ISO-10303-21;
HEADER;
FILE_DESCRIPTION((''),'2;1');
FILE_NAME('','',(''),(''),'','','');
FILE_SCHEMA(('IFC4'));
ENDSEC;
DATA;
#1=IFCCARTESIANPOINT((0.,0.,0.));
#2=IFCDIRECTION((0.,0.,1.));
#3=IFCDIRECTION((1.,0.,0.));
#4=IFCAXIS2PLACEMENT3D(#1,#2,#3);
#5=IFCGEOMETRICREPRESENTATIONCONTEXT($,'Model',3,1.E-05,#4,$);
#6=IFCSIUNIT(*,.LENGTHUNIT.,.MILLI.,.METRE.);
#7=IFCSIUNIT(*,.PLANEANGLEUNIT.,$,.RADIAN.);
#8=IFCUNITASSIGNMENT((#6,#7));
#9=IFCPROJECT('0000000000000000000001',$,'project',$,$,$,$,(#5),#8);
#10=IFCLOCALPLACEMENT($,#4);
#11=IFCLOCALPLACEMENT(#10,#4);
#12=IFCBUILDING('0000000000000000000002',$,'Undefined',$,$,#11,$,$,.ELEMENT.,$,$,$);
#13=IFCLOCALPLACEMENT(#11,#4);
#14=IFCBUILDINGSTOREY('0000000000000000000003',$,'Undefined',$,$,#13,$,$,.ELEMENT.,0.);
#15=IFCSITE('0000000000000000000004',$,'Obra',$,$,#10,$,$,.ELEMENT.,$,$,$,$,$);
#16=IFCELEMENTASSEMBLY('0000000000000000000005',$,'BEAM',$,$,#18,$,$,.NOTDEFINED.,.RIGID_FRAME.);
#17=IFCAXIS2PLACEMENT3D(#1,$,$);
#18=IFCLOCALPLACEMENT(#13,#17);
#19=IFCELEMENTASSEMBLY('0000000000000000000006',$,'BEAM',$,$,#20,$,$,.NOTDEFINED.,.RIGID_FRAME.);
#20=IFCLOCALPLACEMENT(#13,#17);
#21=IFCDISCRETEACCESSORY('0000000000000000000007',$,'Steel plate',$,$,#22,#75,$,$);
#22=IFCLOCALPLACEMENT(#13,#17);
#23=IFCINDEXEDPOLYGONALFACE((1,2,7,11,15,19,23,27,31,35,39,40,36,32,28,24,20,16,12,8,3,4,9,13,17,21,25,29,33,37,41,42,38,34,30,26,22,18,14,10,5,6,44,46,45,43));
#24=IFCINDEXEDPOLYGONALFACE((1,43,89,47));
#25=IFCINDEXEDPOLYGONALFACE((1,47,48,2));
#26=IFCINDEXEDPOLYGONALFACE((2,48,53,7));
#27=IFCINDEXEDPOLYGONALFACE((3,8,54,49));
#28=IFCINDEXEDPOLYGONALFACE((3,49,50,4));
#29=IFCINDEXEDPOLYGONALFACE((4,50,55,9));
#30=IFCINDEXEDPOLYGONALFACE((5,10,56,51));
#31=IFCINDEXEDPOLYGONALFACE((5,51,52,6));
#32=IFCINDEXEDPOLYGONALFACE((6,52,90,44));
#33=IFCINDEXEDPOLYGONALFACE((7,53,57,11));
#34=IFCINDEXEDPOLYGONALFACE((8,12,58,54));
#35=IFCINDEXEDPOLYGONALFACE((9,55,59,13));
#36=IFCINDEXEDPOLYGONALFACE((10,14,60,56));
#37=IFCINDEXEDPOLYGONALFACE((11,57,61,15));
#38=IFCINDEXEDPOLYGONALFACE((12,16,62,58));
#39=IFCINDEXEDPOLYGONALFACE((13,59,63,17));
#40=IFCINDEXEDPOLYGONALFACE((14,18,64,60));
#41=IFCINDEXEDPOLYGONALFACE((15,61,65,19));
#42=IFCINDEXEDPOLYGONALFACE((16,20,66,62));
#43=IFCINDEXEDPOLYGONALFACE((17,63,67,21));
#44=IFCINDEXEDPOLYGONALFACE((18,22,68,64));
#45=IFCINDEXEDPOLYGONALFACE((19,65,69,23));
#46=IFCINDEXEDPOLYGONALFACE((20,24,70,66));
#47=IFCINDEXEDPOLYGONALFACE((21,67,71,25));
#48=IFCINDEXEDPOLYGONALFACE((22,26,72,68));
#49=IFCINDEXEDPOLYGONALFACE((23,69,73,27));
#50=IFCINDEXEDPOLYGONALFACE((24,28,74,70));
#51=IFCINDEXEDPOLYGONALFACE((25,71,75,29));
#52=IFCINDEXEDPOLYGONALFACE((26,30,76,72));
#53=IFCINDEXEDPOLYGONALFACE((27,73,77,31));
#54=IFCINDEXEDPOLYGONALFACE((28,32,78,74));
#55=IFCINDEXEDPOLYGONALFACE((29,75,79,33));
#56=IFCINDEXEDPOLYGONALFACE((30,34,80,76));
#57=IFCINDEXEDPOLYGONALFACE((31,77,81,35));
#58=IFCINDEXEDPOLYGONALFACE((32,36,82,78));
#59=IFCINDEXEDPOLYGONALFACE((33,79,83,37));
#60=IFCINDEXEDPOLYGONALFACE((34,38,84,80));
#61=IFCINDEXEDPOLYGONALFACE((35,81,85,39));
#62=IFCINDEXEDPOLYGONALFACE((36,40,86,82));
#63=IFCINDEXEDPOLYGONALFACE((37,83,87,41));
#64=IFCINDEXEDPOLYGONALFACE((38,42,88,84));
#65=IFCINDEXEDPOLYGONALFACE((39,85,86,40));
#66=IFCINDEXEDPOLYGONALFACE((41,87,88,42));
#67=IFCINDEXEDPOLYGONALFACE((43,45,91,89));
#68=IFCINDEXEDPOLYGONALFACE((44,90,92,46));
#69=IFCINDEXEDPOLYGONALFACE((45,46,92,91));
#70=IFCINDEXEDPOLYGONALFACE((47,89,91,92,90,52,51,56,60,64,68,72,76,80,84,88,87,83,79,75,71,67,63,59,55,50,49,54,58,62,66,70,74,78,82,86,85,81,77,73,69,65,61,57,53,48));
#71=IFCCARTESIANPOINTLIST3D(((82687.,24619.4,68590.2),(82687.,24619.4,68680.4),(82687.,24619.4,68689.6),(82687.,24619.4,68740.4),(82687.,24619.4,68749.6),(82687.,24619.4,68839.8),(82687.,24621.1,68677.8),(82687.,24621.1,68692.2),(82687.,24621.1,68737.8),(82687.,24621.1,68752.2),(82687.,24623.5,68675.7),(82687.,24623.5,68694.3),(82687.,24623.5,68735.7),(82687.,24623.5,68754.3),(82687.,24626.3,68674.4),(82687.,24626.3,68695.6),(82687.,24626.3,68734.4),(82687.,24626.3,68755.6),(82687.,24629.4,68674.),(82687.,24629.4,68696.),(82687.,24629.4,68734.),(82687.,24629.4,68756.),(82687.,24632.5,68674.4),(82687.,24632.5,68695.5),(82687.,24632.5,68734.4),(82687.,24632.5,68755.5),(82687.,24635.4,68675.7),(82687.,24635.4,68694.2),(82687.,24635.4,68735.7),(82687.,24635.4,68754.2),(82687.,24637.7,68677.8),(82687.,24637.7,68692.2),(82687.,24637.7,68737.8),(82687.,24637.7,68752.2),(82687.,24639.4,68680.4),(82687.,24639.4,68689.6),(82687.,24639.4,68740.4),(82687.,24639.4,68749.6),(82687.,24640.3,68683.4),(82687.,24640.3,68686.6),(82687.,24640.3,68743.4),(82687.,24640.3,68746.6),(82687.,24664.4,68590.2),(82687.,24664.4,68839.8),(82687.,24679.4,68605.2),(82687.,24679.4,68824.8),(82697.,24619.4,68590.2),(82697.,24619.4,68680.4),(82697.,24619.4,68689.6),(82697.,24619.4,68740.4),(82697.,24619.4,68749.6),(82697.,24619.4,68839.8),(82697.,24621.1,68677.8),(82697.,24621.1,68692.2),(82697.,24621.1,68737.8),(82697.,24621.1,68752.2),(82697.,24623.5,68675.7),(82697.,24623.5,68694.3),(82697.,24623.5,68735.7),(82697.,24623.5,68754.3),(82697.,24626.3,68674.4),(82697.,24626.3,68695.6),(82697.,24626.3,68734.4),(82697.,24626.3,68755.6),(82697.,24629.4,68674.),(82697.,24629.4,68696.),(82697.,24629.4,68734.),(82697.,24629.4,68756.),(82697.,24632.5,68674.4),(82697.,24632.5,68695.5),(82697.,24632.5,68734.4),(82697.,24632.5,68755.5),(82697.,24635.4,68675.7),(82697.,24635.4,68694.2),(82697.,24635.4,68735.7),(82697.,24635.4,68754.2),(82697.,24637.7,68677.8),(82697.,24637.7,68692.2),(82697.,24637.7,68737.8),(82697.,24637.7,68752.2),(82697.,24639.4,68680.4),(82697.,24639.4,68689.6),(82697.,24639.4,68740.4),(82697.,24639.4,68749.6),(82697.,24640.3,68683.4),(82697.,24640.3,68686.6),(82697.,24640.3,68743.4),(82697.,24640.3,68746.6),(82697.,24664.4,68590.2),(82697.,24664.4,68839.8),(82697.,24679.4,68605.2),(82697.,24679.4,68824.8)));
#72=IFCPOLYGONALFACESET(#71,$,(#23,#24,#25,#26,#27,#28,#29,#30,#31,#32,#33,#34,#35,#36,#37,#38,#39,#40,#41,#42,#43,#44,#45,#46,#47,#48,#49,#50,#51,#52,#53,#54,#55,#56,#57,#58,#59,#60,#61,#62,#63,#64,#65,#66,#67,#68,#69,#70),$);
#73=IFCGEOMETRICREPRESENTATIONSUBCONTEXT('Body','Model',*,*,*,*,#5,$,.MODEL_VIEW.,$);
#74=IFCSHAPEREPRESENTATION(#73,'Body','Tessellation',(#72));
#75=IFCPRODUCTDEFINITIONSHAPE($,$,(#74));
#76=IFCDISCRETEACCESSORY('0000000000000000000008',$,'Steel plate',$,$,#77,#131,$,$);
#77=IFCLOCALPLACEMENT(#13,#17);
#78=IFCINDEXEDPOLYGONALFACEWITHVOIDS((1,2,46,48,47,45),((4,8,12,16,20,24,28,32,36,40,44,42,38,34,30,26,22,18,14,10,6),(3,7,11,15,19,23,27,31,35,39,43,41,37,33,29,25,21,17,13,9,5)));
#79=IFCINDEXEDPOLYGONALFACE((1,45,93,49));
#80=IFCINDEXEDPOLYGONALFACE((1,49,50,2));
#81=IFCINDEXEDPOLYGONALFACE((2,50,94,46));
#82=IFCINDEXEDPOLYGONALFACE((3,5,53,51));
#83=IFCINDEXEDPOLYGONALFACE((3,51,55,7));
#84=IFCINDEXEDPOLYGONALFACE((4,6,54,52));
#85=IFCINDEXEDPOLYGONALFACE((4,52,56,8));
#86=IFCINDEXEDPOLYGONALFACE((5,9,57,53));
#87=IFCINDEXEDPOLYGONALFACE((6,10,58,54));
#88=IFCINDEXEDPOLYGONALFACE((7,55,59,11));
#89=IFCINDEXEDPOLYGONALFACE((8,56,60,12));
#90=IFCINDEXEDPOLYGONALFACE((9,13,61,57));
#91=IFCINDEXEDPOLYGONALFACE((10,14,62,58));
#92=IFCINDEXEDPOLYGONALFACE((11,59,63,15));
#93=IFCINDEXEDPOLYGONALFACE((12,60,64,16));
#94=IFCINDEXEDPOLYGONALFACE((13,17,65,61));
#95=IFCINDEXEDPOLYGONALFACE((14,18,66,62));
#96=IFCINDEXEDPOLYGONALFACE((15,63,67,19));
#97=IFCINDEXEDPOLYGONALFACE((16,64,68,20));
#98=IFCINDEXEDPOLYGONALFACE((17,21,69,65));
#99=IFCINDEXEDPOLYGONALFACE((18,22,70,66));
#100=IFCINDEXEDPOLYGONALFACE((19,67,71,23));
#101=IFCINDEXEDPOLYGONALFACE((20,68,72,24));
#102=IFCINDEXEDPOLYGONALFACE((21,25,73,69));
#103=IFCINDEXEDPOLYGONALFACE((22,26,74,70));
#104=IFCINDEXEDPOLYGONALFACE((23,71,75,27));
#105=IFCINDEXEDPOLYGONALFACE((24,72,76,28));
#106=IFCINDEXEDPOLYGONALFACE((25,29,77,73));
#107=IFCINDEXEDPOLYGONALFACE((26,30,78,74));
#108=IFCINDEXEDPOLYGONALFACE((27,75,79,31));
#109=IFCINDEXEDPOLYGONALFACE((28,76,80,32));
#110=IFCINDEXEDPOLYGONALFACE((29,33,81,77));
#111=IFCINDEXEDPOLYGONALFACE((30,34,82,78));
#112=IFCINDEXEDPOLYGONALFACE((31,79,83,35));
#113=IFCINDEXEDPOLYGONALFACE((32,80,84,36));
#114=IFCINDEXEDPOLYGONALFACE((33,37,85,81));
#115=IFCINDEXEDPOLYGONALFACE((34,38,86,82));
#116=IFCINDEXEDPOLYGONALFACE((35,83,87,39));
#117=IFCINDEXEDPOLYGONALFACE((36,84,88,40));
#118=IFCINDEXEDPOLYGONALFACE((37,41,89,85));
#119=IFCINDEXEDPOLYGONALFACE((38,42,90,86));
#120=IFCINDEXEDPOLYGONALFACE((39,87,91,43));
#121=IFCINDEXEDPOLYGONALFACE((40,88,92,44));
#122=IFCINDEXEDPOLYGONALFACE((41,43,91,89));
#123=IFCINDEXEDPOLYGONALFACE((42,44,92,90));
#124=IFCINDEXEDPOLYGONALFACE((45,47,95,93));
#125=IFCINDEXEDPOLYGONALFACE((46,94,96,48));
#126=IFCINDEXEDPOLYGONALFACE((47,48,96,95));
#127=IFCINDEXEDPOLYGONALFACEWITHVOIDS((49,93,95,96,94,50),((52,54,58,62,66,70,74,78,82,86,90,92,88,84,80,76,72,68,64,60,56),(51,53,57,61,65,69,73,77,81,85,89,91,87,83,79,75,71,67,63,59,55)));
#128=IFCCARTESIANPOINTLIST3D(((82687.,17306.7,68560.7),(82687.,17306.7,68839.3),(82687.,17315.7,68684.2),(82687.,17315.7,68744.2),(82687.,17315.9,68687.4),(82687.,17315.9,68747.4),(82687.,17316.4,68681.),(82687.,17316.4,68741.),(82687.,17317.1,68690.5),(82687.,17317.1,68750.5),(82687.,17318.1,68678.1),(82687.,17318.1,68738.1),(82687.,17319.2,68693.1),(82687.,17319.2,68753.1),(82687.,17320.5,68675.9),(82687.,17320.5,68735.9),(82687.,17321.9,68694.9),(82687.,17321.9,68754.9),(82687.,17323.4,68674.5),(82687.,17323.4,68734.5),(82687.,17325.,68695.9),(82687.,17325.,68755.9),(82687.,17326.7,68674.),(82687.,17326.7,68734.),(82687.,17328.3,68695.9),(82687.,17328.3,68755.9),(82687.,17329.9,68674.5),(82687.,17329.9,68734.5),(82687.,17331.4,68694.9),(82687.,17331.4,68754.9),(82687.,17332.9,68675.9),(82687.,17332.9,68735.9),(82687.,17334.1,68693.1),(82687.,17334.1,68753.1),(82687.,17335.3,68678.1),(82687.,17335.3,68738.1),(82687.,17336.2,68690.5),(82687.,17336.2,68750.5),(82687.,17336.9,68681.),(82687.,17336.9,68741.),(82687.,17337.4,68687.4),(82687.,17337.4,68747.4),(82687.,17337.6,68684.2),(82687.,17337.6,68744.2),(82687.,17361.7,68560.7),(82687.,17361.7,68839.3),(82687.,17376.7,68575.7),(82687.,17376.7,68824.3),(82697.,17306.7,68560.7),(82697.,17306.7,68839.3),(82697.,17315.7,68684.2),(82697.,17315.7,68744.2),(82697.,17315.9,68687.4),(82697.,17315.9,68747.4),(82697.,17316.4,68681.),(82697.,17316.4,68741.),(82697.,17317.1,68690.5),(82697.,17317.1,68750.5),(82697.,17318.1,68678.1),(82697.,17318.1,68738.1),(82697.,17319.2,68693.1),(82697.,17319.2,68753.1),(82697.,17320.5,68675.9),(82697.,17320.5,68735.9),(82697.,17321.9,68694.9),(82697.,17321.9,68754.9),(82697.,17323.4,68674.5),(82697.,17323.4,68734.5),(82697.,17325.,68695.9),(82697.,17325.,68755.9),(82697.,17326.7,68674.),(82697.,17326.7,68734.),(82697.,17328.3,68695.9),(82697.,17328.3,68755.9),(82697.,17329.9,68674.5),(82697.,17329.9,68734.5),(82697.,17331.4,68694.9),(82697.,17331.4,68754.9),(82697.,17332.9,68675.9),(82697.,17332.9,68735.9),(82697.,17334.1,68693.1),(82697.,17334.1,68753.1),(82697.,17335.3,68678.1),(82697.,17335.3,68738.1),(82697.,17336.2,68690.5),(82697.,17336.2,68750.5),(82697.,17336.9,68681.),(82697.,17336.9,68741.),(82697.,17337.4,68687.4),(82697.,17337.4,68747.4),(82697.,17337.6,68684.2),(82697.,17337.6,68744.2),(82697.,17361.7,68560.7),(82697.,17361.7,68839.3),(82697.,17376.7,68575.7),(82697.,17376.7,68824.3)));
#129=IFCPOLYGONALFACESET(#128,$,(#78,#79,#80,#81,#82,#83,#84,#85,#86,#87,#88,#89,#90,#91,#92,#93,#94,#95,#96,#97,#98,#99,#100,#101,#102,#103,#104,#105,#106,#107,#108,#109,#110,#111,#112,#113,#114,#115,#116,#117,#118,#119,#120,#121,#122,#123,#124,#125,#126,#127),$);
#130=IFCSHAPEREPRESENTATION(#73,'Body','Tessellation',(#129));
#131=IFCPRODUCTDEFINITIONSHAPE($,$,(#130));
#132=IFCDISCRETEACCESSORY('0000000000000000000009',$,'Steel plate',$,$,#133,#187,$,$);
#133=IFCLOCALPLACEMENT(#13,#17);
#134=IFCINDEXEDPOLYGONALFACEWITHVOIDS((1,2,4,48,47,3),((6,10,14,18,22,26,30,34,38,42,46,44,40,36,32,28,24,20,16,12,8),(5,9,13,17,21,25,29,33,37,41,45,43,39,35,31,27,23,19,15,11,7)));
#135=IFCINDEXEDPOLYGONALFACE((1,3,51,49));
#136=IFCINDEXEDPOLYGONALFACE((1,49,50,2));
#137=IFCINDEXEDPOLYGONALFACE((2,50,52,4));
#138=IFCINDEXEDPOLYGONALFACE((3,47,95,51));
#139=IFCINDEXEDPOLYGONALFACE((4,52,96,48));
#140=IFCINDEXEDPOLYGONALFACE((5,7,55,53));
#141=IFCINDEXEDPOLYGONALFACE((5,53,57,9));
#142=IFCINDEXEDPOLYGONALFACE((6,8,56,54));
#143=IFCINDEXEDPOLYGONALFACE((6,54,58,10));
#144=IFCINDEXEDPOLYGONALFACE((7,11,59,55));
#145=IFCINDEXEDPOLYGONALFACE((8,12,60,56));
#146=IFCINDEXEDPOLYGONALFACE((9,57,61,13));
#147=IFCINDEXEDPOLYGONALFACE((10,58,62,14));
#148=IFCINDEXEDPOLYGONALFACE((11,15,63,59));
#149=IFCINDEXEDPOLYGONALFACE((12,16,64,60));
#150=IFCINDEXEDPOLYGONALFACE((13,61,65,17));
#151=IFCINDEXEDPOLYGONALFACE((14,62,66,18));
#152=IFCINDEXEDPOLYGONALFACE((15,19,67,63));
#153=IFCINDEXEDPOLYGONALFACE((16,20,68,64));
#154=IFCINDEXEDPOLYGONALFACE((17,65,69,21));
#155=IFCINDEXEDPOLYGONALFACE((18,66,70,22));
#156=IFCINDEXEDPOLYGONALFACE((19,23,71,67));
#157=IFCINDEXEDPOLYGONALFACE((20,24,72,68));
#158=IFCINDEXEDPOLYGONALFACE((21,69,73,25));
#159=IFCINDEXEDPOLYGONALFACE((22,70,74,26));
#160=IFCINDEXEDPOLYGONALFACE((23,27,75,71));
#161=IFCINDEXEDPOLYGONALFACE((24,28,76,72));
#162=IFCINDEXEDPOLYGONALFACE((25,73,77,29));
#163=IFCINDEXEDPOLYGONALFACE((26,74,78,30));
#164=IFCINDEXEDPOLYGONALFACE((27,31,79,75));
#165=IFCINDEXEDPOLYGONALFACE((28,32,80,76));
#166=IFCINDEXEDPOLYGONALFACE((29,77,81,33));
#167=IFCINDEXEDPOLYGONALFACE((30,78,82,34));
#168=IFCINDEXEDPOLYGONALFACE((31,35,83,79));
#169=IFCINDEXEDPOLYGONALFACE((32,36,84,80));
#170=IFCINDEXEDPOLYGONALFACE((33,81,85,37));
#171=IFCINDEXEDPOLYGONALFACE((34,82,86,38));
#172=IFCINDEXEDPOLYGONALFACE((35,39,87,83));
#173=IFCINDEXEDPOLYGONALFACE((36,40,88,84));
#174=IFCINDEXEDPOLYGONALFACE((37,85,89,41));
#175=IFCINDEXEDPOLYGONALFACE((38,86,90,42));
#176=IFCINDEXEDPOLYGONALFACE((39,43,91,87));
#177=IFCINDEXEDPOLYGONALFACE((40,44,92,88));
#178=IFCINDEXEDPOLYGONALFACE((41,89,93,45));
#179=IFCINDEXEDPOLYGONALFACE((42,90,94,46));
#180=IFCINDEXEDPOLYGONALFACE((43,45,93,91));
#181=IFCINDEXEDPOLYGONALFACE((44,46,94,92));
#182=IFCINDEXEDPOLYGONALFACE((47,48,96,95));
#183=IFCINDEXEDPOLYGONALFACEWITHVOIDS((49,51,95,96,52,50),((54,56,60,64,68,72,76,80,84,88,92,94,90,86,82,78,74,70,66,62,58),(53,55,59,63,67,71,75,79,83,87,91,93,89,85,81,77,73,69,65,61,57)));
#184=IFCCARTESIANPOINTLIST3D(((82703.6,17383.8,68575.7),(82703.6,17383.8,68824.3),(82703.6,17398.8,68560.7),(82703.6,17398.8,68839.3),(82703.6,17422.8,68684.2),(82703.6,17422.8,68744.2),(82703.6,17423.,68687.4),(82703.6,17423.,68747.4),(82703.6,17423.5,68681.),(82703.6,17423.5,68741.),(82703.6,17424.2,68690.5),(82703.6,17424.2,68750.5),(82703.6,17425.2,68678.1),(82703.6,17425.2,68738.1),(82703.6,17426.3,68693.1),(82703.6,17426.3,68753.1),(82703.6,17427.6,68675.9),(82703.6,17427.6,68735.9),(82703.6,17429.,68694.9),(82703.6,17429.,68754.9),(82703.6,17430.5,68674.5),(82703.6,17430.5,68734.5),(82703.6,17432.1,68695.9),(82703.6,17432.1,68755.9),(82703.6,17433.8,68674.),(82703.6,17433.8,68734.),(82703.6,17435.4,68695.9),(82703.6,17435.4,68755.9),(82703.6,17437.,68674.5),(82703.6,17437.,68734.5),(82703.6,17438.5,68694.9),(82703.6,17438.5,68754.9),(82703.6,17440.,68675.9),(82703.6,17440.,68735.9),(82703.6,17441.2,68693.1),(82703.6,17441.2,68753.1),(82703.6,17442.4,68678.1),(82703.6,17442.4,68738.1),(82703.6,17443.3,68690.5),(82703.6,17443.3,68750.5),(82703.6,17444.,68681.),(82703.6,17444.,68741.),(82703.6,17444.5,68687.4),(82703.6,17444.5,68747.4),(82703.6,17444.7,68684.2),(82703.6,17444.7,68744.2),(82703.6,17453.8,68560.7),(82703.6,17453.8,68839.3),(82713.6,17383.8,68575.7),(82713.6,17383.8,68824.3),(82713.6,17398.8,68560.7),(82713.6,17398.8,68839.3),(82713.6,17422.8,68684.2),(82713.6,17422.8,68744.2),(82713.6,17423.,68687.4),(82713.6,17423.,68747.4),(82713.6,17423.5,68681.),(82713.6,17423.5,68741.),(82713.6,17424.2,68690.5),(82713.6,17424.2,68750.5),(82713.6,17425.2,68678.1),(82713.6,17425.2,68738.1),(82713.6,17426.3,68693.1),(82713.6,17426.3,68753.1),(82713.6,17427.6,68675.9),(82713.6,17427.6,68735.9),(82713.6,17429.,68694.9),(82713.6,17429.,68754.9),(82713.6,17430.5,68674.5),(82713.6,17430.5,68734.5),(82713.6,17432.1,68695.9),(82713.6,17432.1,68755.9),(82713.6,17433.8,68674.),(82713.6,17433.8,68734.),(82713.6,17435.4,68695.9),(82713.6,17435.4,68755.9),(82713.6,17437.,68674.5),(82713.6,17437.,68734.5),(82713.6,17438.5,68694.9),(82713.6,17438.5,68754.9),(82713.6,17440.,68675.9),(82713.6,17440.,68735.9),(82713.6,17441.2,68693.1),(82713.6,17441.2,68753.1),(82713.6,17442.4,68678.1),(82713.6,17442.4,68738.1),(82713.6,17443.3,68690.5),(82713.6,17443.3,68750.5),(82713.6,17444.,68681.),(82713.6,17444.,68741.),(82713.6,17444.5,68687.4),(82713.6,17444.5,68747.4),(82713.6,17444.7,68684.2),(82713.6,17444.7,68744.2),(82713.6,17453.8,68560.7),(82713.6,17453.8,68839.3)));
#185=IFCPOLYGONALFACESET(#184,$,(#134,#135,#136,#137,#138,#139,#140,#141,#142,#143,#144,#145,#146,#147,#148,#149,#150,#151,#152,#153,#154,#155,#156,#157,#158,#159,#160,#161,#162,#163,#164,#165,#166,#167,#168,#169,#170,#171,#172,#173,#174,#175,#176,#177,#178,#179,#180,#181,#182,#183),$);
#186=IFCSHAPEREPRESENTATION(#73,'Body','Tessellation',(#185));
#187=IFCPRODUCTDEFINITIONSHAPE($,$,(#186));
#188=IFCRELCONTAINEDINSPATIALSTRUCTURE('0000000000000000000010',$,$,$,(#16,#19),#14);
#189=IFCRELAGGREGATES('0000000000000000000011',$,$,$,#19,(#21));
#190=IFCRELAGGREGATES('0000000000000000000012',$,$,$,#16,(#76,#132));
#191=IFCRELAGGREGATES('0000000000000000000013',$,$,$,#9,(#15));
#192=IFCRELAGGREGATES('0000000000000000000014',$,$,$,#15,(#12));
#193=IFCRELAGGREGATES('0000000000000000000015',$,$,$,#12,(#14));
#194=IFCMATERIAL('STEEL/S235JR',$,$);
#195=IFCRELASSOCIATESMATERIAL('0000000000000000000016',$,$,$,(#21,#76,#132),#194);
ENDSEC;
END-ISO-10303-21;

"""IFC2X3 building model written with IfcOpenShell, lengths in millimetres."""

from ifc_helpers import new_model, si_unit, frame, origin_with_axes, origin_2d_with_axis, place, context, subcontext, project, spatial, polyline, circle, outline, extrude, source, transform, mapped, material, element, aggregate, save


model = new_model("IFC2X3")

# Units and contexts
model_context = context("Model", 3, precision=1e-05, world=origin_with_axes())
body_context = subcontext(model_context, "Body", "Model", "MODEL_VIEW")
ifc_project = project(units=[si_unit("LENGTHUNIT", "METRE", prefix="MILLI"), si_unit("PLANEANGLEUNIT", "RADIAN")], contexts=[model_context])

# Site, building, storey
site_placement = place(None, origin_with_axes())
site = spatial("IfcSite", under=ifc_project, at=site_placement, Name="Obra", CompositionType="ELEMENT")
building_placement = place(site_placement, origin_with_axes())
building = spatial("IfcBuilding", under=site, at=building_placement, Name="Undefined", CompositionType="ELEMENT")
storey_placement = place(building_placement, origin_with_axes())
storey = spatial("IfcBuildingStorey", under=building, at=storey_placement, Name="Undefined", CompositionType="ELEMENT", Elevation=0.0)

# Shared definitions
ifc_material = material(Name="STEEL/S235JR")

# Element assembly
assembly_1_placement = place(storey_placement, origin_with_axes())
assembly_1 = element("IfcElementAssembly", 1, at=assembly_1_placement, inside=storey, Name="BEAM", AssemblyPlace="NOTDEFINED", PredefinedType="RIGID_FRAME")

# Element assembly, discrete accessory, opening
assembly_2_placement = place(storey_placement, origin_with_axes())
assembly_2 = element("IfcElementAssembly", 2, at=assembly_2_placement, inside=storey, Name="BEAM", AssemblyPlace="NOTDEFINED", PredefinedType="RIGID_FRAME")
discrete_accessory_1_placement = place(assembly_2_placement, frame((82692.0, 24619.4, 68590.2), z_axis=(1.0, 0.000001, 0.0), x_axis=(-0.000002, 1.0, 0.0)))
discrete_accessory_1 = element("IfcDiscreteAccessory", 3, at=discrete_accessory_1_placement, material=ifc_material, Name="Steel plate", context=body_context, shape_type="SweptSolid", body=[
    extrude(outline(polyline([(0.0, 0.0), (45.0, 0.0), (60.0, 15.0), (60.0, 234.6), (45.0, 249.6), (0.0, 249.6), (0.0, 0.0)])), frame((0.0, 0.0, -5.0), z_axis=(0.0, 0.0, 1.0), x_axis=(1.0, 0.0, 0.0)), (0.0, 0.0, 1.0), 10.0),
])
shared_shape_1 = source(origin_with_axes(), body_context, "Body", "SweptSolid", [
    extrude(circle(Radius=11.0, at=origin_2d_with_axis()), frame((0.0, -13.4, 0.0), z_axis=(0.0, 1.0, 0.0), x_axis=(1.0, 0.0, 0.0)), (0.0, 0.0, 1.0), 10.2),
])
opening_1_placement = place(assembly_2_placement, frame((82700.3, 24669.4, 68850.0), z_axis=(0.000002, -1.0, 0.0), x_axis=(0.0, 0.0, -1.0)))
element("IfcOpeningElement", 4, at=opening_1_placement, cuts=discrete_accessory_1, ObjectType="Opening", context=body_context, shape_type="MappedRepresentation", body=[
    mapped(shared_shape_1, transform((105.0, 0.0, 40.0))),
    mapped(shared_shape_1, transform((165.0, 0.0, 40.0))),
])

# Discrete accessories, openings
discrete_accessory_2_placement = place(assembly_1_placement, frame((82692.0, 17306.7, 68560.7), z_axis=(1.0, 0.0, 0.0), x_axis=(0.0, 1.0, 0.0)))
discrete_accessory_2 = element("IfcDiscreteAccessory", 5, at=discrete_accessory_2_placement, material=ifc_material, Name="Steel plate", context=body_context, shape_type="SweptSolid", body=[
    extrude(outline(polyline([(0.0, 0.0), (55.0, 0.0), (70.0, 15.0), (70.0, 263.6), (55.0, 278.6), (0.0, 278.6), (0.0, 0.0)])), frame((0.0, 0.0, -5.0), z_axis=(0.0, 0.0, 1.0), x_axis=(1.0, 0.0, 0.0)), (0.0, 0.0, 1.0), 10.0),
])
opening_2_placement = place(assembly_1_placement, frame((82700.3, 17366.7, 68850.0), z_axis=(0.0, -1.0, 0.0), x_axis=(0.0, 0.0, -1.0)))
element("IfcOpeningElement", 6, at=opening_2_placement, cuts=discrete_accessory_2, ObjectType="Opening", context=body_context, shape_type="MappedRepresentation", body=[
    mapped(shared_shape_1, transform((105.0, 0.0, 40.0))),
    mapped(shared_shape_1, transform((165.0, 0.0, 40.0))),
])
discrete_accessory_3_placement = place(assembly_1_placement, frame((82708.6, 17453.8, 68560.7), z_axis=(-1.0, 0.0, 0.0), x_axis=(0.0, -1.0, 0.0)))
discrete_accessory_3 = element("IfcDiscreteAccessory", 7, at=discrete_accessory_3_placement, material=ifc_material, Name="Steel plate", context=body_context, shape_type="SweptSolid", body=[
    extrude(outline(polyline([(0.0, 0.0), (55.0, 0.0), (70.0, 15.0), (70.0, 263.6), (55.0, 278.6), (0.0, 278.6), (0.0, 0.0)])), frame((0.0, 0.0, -5.0), z_axis=(0.0, 0.0, 1.0), x_axis=(1.0, 0.0, 0.0)), (0.0, 0.0, 1.0), 10.0),
])
opening_3_placement = place(assembly_1_placement, frame((82700.3, 17393.8, 68850.0), z_axis=(0.0, 1.0, 0.0), x_axis=(0.0, 0.0, -1.0)))
element("IfcOpeningElement", 8, at=opening_3_placement, cuts=discrete_accessory_3, ObjectType="Opening", context=body_context, shape_type="MappedRepresentation", body=[
    mapped(shared_shape_1, transform((105.0, 0.0, 40.0))),
    mapped(shared_shape_1, transform((165.0, 0.0, 40.0))),
])
aggregate(assembly_2, [discrete_accessory_1])
aggregate(assembly_1, [discrete_accessory_2, discrete_accessory_3])

save(model, "model.ifc")
